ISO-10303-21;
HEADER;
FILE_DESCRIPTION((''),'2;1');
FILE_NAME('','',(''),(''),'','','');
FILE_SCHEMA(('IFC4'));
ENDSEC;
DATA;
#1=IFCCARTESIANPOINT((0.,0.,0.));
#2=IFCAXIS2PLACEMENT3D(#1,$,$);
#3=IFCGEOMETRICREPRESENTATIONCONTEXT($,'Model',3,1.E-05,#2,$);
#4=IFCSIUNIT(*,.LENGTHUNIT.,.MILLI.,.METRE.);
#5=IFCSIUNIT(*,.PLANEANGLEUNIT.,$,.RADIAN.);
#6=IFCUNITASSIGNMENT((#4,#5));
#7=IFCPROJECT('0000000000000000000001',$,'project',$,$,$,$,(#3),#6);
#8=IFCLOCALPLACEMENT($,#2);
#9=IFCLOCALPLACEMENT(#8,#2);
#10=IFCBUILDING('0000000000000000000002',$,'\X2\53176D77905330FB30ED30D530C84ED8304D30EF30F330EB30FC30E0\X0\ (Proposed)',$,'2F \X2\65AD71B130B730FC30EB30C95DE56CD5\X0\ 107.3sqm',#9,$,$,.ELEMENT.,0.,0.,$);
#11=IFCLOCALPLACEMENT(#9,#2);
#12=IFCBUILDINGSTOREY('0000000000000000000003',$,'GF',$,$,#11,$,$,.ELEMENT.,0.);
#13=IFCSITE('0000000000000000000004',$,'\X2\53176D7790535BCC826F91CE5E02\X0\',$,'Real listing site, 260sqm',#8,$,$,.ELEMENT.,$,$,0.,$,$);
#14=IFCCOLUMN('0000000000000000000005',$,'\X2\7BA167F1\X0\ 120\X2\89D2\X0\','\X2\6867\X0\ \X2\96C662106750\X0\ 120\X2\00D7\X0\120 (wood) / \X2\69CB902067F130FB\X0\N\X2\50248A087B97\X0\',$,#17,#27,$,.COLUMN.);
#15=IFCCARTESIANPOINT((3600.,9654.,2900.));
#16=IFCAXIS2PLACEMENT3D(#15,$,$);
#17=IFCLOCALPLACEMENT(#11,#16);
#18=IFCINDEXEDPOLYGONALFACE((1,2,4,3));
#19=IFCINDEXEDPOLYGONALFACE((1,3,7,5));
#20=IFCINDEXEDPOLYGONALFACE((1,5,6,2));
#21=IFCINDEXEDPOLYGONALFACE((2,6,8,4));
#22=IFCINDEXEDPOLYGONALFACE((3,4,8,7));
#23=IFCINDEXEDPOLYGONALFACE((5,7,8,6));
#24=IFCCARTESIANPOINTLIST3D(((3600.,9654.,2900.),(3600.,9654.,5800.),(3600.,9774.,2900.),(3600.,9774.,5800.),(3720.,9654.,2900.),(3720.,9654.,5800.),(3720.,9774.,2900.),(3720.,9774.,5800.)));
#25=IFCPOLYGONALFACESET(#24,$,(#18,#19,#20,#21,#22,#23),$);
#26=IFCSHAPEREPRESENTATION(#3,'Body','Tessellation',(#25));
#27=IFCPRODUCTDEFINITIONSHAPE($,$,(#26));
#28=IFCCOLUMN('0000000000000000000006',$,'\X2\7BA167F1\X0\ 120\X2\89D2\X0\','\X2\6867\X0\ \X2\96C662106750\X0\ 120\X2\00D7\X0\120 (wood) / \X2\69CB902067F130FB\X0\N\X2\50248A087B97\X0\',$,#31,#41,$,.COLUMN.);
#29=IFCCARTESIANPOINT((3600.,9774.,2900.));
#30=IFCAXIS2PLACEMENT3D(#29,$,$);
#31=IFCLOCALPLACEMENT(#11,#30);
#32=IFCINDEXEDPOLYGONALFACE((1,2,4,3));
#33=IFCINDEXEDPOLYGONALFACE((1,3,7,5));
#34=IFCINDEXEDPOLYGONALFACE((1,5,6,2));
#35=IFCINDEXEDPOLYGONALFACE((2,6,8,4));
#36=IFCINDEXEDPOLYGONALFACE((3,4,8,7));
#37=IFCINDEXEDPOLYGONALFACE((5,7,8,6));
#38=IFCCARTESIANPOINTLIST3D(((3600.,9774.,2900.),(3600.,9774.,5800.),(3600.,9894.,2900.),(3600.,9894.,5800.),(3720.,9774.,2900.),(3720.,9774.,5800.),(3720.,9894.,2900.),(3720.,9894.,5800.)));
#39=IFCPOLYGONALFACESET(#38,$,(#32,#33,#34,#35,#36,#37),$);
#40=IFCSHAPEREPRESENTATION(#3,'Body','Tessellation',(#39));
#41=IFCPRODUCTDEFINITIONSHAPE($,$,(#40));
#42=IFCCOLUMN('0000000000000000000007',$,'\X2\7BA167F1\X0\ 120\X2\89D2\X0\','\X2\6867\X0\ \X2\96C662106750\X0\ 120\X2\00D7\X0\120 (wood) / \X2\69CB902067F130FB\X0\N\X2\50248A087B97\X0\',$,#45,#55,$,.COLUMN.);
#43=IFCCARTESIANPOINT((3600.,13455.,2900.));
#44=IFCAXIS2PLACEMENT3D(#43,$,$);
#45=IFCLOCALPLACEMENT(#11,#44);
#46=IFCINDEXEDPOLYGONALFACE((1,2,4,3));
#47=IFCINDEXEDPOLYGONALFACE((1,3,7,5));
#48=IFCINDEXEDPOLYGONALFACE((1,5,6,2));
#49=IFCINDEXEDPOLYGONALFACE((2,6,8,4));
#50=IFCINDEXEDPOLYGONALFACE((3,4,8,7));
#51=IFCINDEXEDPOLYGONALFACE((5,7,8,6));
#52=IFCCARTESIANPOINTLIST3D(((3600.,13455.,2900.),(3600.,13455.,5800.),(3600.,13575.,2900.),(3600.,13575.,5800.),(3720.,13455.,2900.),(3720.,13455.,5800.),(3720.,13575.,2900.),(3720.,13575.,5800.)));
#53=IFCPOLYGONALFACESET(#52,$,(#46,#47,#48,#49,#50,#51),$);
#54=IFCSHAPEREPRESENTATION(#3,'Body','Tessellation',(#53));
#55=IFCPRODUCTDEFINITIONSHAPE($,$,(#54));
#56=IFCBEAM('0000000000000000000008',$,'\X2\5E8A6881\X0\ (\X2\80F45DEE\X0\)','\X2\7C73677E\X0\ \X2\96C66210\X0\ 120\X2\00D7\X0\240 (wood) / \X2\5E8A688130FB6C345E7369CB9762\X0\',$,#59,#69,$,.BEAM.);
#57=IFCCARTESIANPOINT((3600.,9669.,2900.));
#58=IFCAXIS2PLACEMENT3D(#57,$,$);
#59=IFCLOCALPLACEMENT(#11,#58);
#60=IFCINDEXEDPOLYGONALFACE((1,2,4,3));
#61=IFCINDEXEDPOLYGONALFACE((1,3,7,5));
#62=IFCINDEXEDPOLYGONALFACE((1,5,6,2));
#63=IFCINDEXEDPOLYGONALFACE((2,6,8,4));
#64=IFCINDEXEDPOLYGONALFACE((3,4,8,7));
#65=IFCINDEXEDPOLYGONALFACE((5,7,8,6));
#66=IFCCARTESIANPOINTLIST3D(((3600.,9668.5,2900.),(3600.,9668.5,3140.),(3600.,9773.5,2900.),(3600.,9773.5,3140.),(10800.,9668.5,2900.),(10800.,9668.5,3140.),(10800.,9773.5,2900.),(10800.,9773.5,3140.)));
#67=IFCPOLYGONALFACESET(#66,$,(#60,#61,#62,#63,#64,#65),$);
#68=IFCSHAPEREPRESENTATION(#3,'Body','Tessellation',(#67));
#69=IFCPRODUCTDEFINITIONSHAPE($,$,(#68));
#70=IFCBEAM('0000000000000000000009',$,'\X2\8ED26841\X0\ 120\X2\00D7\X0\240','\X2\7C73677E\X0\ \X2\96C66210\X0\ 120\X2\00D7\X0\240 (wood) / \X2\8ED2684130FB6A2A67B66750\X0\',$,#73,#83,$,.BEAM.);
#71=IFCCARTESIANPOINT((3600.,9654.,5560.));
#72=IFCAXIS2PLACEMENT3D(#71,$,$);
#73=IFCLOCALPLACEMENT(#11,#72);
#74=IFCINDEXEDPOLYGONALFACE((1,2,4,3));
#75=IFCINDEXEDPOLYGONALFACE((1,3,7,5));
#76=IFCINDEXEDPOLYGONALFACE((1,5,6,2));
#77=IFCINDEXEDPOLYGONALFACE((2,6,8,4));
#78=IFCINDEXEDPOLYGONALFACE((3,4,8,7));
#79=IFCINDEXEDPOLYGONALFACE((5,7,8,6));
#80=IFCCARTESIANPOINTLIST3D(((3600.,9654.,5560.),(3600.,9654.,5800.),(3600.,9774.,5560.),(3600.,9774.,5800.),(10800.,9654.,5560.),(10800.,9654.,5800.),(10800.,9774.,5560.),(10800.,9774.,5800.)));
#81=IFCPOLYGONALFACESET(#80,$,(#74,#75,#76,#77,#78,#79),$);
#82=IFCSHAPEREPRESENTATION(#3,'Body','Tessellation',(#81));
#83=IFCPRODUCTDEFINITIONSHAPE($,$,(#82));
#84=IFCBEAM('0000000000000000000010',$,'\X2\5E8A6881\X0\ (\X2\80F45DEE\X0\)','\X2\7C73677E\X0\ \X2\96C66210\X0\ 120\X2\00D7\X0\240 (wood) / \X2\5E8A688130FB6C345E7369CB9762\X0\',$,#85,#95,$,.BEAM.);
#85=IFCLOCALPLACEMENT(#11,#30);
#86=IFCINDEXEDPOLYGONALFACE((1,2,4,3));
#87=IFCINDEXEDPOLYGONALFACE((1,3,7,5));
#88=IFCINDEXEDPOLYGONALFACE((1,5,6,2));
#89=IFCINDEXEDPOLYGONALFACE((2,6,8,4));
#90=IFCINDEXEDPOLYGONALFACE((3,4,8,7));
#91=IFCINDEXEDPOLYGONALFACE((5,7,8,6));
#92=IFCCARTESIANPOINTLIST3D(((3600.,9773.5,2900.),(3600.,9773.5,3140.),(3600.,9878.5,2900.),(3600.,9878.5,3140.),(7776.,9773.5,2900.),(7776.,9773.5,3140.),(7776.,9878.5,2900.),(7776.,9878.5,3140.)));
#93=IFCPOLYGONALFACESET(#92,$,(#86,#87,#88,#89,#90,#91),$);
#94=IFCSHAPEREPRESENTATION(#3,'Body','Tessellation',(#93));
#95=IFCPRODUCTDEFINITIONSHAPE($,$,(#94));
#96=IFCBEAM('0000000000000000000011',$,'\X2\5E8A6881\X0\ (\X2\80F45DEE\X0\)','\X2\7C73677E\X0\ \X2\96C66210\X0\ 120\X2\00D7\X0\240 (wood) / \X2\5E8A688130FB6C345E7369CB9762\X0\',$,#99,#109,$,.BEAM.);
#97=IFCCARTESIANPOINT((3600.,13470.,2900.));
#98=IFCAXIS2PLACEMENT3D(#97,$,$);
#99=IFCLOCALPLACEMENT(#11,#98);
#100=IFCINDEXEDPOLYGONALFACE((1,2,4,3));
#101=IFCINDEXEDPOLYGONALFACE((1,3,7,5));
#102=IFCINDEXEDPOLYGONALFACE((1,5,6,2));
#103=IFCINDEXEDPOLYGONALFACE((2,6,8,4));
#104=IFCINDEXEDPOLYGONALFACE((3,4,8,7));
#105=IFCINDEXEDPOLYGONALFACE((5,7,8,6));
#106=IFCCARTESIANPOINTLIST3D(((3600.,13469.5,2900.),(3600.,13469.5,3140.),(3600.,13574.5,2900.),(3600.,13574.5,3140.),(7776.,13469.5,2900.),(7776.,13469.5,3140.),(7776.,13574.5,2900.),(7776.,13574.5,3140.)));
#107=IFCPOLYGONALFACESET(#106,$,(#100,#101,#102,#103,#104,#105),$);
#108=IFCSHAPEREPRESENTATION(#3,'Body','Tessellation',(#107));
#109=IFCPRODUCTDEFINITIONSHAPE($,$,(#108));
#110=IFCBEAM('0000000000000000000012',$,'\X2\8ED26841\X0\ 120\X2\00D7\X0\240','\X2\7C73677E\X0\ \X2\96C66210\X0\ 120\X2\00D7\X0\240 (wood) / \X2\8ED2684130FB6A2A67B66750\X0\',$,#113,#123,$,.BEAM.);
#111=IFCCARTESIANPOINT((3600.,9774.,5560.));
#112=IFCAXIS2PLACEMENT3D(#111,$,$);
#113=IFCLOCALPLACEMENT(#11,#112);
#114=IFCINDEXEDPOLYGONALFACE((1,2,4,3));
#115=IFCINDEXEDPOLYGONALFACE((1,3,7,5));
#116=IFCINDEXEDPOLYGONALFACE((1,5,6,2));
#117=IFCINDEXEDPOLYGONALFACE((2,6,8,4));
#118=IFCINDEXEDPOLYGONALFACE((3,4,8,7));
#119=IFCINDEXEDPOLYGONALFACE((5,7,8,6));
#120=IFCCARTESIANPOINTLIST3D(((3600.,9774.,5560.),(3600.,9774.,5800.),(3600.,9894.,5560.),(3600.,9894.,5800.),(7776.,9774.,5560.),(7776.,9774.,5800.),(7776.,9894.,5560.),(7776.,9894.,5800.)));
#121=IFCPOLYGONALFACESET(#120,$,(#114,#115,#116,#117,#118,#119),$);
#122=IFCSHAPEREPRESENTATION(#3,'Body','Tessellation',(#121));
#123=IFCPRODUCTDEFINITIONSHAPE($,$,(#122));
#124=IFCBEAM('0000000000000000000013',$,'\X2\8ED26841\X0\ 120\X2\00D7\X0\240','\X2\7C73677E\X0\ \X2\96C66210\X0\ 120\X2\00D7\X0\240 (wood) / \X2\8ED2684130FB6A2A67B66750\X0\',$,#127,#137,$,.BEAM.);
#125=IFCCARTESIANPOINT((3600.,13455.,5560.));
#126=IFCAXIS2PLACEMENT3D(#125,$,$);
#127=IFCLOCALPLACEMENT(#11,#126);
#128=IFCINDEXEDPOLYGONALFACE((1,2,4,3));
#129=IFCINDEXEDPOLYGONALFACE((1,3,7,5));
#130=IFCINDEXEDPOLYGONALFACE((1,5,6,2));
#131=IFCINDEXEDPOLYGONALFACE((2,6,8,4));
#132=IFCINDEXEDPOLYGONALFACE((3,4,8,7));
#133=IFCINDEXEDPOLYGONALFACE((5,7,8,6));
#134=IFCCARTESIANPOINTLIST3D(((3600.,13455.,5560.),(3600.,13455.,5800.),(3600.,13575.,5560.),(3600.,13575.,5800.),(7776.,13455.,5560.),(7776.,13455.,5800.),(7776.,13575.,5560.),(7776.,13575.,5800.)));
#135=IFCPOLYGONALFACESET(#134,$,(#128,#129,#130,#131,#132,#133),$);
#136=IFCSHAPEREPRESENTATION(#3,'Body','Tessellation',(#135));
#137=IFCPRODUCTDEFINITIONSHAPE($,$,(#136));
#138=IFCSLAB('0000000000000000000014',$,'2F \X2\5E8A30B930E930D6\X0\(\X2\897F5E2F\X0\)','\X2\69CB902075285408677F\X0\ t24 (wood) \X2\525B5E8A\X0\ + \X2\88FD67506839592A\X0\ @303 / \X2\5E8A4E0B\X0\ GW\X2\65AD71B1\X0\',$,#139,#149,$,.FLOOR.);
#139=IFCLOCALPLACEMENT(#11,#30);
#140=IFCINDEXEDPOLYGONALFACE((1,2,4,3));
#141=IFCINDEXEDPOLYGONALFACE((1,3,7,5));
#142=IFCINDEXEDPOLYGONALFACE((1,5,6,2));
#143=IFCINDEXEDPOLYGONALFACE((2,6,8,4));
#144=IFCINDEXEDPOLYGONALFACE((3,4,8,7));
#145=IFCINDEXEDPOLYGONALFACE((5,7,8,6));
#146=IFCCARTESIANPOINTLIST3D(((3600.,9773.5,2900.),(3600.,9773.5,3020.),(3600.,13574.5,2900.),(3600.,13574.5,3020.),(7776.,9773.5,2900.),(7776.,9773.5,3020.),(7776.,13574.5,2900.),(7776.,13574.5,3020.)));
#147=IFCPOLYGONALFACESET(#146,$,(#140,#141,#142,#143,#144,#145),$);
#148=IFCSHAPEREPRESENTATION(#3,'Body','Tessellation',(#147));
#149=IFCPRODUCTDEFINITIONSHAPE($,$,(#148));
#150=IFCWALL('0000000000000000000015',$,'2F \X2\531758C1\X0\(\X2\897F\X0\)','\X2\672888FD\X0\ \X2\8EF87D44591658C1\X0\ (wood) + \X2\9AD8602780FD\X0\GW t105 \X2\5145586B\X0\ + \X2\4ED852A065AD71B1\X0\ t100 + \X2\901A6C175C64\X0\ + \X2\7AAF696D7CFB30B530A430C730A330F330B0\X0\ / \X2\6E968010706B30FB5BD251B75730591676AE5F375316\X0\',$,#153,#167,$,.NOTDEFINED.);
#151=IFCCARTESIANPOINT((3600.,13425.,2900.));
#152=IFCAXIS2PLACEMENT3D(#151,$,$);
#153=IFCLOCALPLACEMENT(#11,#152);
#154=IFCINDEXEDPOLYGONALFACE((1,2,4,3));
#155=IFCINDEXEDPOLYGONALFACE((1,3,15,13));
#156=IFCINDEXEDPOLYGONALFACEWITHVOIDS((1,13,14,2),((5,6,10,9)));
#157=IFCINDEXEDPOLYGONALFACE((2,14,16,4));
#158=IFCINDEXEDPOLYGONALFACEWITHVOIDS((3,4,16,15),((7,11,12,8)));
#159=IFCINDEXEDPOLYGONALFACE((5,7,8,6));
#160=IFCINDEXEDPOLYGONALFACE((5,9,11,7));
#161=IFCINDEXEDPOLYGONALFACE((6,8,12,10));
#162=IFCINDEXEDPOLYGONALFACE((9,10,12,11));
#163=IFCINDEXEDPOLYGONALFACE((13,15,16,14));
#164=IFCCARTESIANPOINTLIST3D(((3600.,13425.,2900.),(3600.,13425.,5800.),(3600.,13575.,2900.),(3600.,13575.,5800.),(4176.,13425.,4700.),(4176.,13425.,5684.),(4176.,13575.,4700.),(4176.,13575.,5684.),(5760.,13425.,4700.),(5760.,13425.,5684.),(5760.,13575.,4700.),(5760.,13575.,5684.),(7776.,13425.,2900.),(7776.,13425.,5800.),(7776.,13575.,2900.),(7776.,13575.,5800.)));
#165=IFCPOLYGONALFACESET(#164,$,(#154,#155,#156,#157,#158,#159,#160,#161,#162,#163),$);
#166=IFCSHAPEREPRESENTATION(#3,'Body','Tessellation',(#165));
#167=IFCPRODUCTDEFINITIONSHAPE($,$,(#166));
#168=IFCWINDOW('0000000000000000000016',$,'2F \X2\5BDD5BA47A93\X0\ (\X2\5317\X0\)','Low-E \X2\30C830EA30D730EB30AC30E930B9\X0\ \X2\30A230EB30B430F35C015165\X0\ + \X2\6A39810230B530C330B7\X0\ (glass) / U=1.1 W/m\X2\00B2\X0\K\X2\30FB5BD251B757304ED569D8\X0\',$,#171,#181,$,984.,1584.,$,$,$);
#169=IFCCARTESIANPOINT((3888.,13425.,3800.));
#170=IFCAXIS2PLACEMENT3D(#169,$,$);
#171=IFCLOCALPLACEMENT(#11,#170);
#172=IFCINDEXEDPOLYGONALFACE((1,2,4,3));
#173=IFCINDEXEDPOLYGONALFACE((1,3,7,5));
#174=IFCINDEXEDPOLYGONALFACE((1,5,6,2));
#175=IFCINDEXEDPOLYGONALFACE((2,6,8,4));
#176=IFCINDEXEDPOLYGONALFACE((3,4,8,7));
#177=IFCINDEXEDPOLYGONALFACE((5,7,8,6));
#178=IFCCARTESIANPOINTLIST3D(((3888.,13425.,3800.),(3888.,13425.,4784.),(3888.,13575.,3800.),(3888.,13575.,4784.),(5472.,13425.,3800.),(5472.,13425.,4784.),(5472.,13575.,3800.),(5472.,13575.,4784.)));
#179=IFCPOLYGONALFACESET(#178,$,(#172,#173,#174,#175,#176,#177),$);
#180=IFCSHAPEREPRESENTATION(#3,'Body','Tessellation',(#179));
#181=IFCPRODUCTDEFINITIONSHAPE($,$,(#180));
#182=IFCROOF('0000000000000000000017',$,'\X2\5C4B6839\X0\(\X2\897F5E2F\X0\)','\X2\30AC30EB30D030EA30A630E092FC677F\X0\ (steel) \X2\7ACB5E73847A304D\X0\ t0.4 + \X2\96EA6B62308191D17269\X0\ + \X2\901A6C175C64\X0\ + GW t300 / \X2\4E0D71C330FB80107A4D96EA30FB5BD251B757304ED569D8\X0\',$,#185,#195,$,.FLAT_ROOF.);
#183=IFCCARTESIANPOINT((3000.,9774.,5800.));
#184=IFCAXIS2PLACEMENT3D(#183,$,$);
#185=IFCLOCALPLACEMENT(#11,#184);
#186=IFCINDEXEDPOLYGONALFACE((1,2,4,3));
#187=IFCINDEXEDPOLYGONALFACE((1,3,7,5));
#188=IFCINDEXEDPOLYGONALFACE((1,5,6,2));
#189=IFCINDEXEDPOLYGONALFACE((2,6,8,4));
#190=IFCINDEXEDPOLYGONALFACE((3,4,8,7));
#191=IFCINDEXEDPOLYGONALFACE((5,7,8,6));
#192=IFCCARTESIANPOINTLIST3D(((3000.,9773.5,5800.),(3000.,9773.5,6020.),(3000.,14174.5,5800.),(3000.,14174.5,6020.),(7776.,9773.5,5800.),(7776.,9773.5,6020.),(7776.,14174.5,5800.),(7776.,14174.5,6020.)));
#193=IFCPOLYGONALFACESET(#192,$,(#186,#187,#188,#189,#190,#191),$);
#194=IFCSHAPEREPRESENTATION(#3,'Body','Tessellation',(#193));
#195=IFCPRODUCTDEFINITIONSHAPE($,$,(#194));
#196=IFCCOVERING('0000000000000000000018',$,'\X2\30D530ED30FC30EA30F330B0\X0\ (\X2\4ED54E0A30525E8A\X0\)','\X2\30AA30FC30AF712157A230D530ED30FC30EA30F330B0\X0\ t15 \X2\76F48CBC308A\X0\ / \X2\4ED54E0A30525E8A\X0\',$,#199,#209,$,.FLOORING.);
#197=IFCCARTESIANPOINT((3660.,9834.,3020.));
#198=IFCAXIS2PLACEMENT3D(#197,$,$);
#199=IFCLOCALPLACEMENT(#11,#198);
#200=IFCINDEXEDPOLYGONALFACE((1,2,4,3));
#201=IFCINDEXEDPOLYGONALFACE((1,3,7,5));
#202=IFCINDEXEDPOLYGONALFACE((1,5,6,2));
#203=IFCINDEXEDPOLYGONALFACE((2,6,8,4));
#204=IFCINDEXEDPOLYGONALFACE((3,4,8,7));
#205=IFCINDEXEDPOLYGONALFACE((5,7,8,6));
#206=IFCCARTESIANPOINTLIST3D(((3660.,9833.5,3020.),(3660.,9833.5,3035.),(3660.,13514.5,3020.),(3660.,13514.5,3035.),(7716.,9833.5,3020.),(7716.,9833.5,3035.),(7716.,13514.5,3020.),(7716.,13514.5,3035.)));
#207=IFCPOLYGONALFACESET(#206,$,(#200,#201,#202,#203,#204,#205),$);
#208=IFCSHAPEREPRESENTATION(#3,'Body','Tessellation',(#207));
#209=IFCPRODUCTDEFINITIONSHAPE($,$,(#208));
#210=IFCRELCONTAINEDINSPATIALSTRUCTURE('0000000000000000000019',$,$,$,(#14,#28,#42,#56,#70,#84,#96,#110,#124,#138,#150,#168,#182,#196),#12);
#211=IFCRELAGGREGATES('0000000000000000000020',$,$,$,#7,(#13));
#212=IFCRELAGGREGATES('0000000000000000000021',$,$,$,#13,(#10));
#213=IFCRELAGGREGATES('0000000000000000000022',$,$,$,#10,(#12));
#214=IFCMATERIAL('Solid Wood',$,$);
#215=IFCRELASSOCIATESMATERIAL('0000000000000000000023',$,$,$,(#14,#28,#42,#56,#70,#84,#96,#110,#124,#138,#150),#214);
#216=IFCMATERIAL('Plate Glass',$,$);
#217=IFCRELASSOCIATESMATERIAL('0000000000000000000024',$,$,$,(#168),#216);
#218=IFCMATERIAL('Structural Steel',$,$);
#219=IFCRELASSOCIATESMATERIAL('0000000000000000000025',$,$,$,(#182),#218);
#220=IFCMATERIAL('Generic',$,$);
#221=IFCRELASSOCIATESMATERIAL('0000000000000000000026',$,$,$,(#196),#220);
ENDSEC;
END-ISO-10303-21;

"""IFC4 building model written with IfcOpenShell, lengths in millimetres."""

from ifc_helpers import new_model, si_unit, frame, frame_2d, origin, place, context, project, spatial, rectangle, extrude, material, element, fill, save


model = new_model("IFC4")

# Units and contexts
model_context = context("Model", 3, precision=1e-05, world=origin())
ifc_project = project(units=[si_unit("LENGTHUNIT", "METRE", prefix="MILLI"), si_unit("PLANEANGLEUNIT", "RADIAN")], contexts=[model_context])

# Site, building, storey
site_placement = place(None, origin())
site = spatial("IfcSite", under=ifc_project, at=site_placement, Name="北海道富良野市", ObjectType="Real listing site, 260sqm", CompositionType="ELEMENT", RefElevation=0.0)
building_placement = place(site_placement, origin())
building = spatial("IfcBuilding", under=site, at=building_placement, Name="北海道・ロフト付きワンルーム (Proposed)", ObjectType="2F 断熱シールド工法 107.3sqm", CompositionType="ELEMENT", ElevationOfRefHeight=0.0, ElevationOfTerrain=0.0)
storey_placement = place(building_placement, origin())
storey = spatial("IfcBuildingStorey", under=building, at=storey_placement, Name="GF", CompositionType="ELEMENT", Elevation=0.0)

# Columns
ifc_material_1 = material(Name="Solid Wood")
column_1_placement = place(storey_placement, frame((3600.0, 9654.0, 2900.0)))
element("IfcColumn", 1, at=column_1_placement, inside=storey, material=ifc_material_1, Name="管柱 120角", Description="桧 集成材 120×120 (wood) / 構造柱・N値計算", PredefinedType="COLUMN", context=model_context, shape_type="SweptSolid", body=[
    extrude(rectangle(XDim=120.0, YDim=120.0, at=frame_2d((60.0, 60.0))), frame((3600.0, 9654.0, 2900.0)), (0.0, 0.0, 1.0), 2900.0),
])
column_2_placement = place(storey_placement, frame((3600.0, 9774.0, 2900.0)))
element("IfcColumn", 2, at=column_2_placement, inside=storey, material=ifc_material_1, Name="管柱 120角", Description="桧 集成材 120×120 (wood) / 構造柱・N値計算", PredefinedType="COLUMN", context=model_context, shape_type="SweptSolid", body=[
    extrude(rectangle(XDim=120.0, YDim=120.0, at=frame_2d((60.0, 60.0))), frame((3600.0, 9774.0, 2900.0)), (0.0, 0.0, 1.0), 2900.0),
])
column_3_placement = place(storey_placement, frame((3600.0, 13455.0, 2900.0)))
element("IfcColumn", 3, at=column_3_placement, inside=storey, material=ifc_material_1, Name="管柱 120角", Description="桧 集成材 120×120 (wood) / 構造柱・N値計算", PredefinedType="COLUMN", context=model_context, shape_type="SweptSolid", body=[
    extrude(rectangle(XDim=120.0, YDim=120.0, at=frame_2d((60.0, 60.0))), frame((3600.0, 13455.0, 2900.0)), (0.0, 0.0, 1.0), 2900.0),
])

# Beams
beam_1_placement = place(storey_placement, frame((3600.0, 9669.0, 2900.0)))
element("IfcBeam", 4, at=beam_1_placement, inside=storey, material=ifc_material_1, Name="床梁 (胴差)", Description="米松 集成 120×240 (wood) / 床梁・水平構面", PredefinedType="BEAM", context=model_context, shape_type="SweptSolid", body=[
    extrude(rectangle(XDim=7200.0, YDim=105.0, at=frame_2d((3600.0, 52.0))), frame((3600.0, 9669.0, 2900.0)), (0.0, 0.0, 1.0), 240.0),
])
beam_2_placement = place(storey_placement, frame((3600.0, 9654.0, 5560.0)))
element("IfcBeam", 5, at=beam_2_placement, inside=storey, material=ifc_material_1, Name="軒桁 120×240", Description="米松 集成 120×240 (wood) / 軒桁・横架材", PredefinedType="BEAM", context=model_context, shape_type="SweptSolid", body=[
    extrude(rectangle(XDim=7200.0, YDim=120.0, at=frame_2d((3600.0, 60.0))), frame((3600.0, 9654.0, 5560.0)), (0.0, 0.0, 1.0), 240.0),
])
beam_3_placement = place(storey_placement, frame((3600.0, 9774.0, 2900.0)))
element("IfcBeam", 6, at=beam_3_placement, inside=storey, material=ifc_material_1, Name="床梁 (胴差)", Description="米松 集成 120×240 (wood) / 床梁・水平構面", PredefinedType="BEAM", context=model_context, shape_type="SweptSolid", body=[
    extrude(rectangle(XDim=4176.0, YDim=105.0, at=frame_2d((2088.0, 52.0))), frame((3600.0, 9774.0, 2900.0)), (0.0, 0.0, 1.0), 240.0),
])
beam_4_placement = place(storey_placement, frame((3600.0, 13470.0, 2900.0)))
element("IfcBeam", 7, at=beam_4_placement, inside=storey, material=ifc_material_1, Name="床梁 (胴差)", Description="米松 集成 120×240 (wood) / 床梁・水平構面", PredefinedType="BEAM", context=model_context, shape_type="SweptSolid", body=[
    extrude(rectangle(XDim=4176.0, YDim=105.0, at=frame_2d((2088.0, 52.0))), frame((3600.0, 13470.0, 2900.0)), (0.0, 0.0, 1.0), 240.0),
])
beam_5_placement = place(storey_placement, frame((3600.0, 9774.0, 5560.0)))
element("IfcBeam", 8, at=beam_5_placement, inside=storey, material=ifc_material_1, Name="軒桁 120×240", Description="米松 集成 120×240 (wood) / 軒桁・横架材", PredefinedType="BEAM", context=model_context, shape_type="SweptSolid", body=[
    extrude(rectangle(XDim=4176.0, YDim=120.0, at=frame_2d((2088.0, 60.0))), frame((3600.0, 9774.0, 5560.0)), (0.0, 0.0, 1.0), 240.0),
])
beam_6_placement = place(storey_placement, frame((3600.0, 13455.0, 5560.0)))
element("IfcBeam", 9, at=beam_6_placement, inside=storey, material=ifc_material_1, Name="軒桁 120×240", Description="米松 集成 120×240 (wood) / 軒桁・横架材", PredefinedType="BEAM", context=model_context, shape_type="SweptSolid", body=[
    extrude(rectangle(XDim=4176.0, YDim=120.0, at=frame_2d((2088.0, 60.0))), frame((3600.0, 13455.0, 5560.0)), (0.0, 0.0, 1.0), 240.0),
])

# Slab
slab_placement = place(storey_placement, frame((3600.0, 9774.0, 2900.0)))
element("IfcSlab", 10, at=slab_placement, inside=storey, material=ifc_material_1, Name="2F 床スラブ(西帯)", Description="構造用合板 t24 (wood) 剛床 + 製材根太 @303 / 床下 GW断熱", PredefinedType="FLOOR", context=model_context, shape_type="SweptSolid", body=[
    extrude(rectangle(XDim=4176.0, YDim=3801.0, at=frame_2d((2088.0, 1900.0))), frame((3600.0, 9774.0, 2900.0)), (0.0, 0.0, 1.0), 120.0),
])

# Wall, opening, window
wall_1_placement = place(storey_placement, frame((3600.0, 13425.0, 2900.0)))
wall_1 = element("IfcWall", 11, at=wall_1_placement, inside=storey, material=ifc_material_1, Name="2F 北壁(西)", Description="木製 軸組外壁 (wood) + 高性能GW t105 充填 + 付加断熱 t100 + 通気層 + 窯業系サイディング / 準耐火・寒冷地外皮強化", PredefinedType="NOTDEFINED", context=model_context, shape_type="SweptSolid", body=[
    extrude(rectangle(XDim=4176.0, YDim=150.0, at=frame_2d((2088.0, 75.0))), frame((3600.0, 13425.0, 2900.0)), (0.0, 0.0, 1.0), 2900.0),
])
opening_placement = place(storey_placement, frame((3888.0, 13425.0, 3800.0)))
opening = element("IfcOpeningElement", 12, at=opening_placement, cuts=wall_1, PredefinedType="NOTDEFINED", context=model_context, shape_type="SweptSolid", body=[
    extrude(rectangle(XDim=1584.0, YDim=150.0, at=frame_2d((792.0, 75.0))), frame((3888.0, 13425.0, 3800.0)), (0.0, 0.0, 1.0), 984.0),
])
ifc_material_2 = material(Name="Plate Glass")
window_placement = place(storey_placement, frame((3888.0, 13425.0, 3800.0)))
window = element("IfcWindow", 13, at=window_placement, inside=storey, material=ifc_material_2, Name="2F 寝室窓 (北)", Description="Low-E トリプルガラス アルゴン封入 + 樹脂サッシ (glass) / U=1.1 W/m²K・寒冷地仕様", OverallHeight=984.0, OverallWidth=1584.0, context=model_context, shape_type="SweptSolid", body=[
    extrude(rectangle(XDim=1584.0, YDim=150.0, at=frame_2d((792.0, 75.0))), frame((3888.0, 13425.0, 3800.0)), (0.0, 0.0, 1.0), 984.0),
])
fill(opening, window)

# Roof
ifc_material_3 = material(Name="Structural Steel")
for number, where, name in (
    (14, (3000.0, 9774.0, 5800.0), "屋根(西帯)"),
):
    element("IfcRoof", number, at=place(storey_placement, frame(where)), inside=storey, material=ifc_material_3, Name=name, Description="ガルバリウム鋼板 (steel) 立平葺き t0.4 + 雪止め金物 + 通気層 + GW t300 / 不燃・耐積雪・寒冷地仕様", PredefinedType="FLAT_ROOF", context=model_context, shape_type="SweptSolid", body=[
        extrude(rectangle(XDim=4776.0, YDim=4401.0, at=frame_2d((2388.0, 2200.0))), frame((3000.0, 9774.0, 5800.0)), (0.0, 0.0, 1.0), 220.0),
    ])

# Covering
ifc_material_4 = material(Name="Generic")
covering_placement = place(storey_placement, frame((3660.0, 9834.0, 3020.0)))
element("IfcCovering", 15, at=covering_placement, inside=storey, material=ifc_material_4, Name="フローリング (仕上げ床)", Description="オーク無垢フローリング t15 直貼り / 仕上げ床", PredefinedType="FLOORING", context=model_context, shape_type="SweptSolid", body=[
    extrude(rectangle(XDim=4056.0, YDim=3681.0, at=frame_2d((2028.0, 1840.0))), frame((3660.0, 9834.0, 3020.0)), (0.0, 0.0, 1.0), 15.0),
])

save(model, "model.ifc")
